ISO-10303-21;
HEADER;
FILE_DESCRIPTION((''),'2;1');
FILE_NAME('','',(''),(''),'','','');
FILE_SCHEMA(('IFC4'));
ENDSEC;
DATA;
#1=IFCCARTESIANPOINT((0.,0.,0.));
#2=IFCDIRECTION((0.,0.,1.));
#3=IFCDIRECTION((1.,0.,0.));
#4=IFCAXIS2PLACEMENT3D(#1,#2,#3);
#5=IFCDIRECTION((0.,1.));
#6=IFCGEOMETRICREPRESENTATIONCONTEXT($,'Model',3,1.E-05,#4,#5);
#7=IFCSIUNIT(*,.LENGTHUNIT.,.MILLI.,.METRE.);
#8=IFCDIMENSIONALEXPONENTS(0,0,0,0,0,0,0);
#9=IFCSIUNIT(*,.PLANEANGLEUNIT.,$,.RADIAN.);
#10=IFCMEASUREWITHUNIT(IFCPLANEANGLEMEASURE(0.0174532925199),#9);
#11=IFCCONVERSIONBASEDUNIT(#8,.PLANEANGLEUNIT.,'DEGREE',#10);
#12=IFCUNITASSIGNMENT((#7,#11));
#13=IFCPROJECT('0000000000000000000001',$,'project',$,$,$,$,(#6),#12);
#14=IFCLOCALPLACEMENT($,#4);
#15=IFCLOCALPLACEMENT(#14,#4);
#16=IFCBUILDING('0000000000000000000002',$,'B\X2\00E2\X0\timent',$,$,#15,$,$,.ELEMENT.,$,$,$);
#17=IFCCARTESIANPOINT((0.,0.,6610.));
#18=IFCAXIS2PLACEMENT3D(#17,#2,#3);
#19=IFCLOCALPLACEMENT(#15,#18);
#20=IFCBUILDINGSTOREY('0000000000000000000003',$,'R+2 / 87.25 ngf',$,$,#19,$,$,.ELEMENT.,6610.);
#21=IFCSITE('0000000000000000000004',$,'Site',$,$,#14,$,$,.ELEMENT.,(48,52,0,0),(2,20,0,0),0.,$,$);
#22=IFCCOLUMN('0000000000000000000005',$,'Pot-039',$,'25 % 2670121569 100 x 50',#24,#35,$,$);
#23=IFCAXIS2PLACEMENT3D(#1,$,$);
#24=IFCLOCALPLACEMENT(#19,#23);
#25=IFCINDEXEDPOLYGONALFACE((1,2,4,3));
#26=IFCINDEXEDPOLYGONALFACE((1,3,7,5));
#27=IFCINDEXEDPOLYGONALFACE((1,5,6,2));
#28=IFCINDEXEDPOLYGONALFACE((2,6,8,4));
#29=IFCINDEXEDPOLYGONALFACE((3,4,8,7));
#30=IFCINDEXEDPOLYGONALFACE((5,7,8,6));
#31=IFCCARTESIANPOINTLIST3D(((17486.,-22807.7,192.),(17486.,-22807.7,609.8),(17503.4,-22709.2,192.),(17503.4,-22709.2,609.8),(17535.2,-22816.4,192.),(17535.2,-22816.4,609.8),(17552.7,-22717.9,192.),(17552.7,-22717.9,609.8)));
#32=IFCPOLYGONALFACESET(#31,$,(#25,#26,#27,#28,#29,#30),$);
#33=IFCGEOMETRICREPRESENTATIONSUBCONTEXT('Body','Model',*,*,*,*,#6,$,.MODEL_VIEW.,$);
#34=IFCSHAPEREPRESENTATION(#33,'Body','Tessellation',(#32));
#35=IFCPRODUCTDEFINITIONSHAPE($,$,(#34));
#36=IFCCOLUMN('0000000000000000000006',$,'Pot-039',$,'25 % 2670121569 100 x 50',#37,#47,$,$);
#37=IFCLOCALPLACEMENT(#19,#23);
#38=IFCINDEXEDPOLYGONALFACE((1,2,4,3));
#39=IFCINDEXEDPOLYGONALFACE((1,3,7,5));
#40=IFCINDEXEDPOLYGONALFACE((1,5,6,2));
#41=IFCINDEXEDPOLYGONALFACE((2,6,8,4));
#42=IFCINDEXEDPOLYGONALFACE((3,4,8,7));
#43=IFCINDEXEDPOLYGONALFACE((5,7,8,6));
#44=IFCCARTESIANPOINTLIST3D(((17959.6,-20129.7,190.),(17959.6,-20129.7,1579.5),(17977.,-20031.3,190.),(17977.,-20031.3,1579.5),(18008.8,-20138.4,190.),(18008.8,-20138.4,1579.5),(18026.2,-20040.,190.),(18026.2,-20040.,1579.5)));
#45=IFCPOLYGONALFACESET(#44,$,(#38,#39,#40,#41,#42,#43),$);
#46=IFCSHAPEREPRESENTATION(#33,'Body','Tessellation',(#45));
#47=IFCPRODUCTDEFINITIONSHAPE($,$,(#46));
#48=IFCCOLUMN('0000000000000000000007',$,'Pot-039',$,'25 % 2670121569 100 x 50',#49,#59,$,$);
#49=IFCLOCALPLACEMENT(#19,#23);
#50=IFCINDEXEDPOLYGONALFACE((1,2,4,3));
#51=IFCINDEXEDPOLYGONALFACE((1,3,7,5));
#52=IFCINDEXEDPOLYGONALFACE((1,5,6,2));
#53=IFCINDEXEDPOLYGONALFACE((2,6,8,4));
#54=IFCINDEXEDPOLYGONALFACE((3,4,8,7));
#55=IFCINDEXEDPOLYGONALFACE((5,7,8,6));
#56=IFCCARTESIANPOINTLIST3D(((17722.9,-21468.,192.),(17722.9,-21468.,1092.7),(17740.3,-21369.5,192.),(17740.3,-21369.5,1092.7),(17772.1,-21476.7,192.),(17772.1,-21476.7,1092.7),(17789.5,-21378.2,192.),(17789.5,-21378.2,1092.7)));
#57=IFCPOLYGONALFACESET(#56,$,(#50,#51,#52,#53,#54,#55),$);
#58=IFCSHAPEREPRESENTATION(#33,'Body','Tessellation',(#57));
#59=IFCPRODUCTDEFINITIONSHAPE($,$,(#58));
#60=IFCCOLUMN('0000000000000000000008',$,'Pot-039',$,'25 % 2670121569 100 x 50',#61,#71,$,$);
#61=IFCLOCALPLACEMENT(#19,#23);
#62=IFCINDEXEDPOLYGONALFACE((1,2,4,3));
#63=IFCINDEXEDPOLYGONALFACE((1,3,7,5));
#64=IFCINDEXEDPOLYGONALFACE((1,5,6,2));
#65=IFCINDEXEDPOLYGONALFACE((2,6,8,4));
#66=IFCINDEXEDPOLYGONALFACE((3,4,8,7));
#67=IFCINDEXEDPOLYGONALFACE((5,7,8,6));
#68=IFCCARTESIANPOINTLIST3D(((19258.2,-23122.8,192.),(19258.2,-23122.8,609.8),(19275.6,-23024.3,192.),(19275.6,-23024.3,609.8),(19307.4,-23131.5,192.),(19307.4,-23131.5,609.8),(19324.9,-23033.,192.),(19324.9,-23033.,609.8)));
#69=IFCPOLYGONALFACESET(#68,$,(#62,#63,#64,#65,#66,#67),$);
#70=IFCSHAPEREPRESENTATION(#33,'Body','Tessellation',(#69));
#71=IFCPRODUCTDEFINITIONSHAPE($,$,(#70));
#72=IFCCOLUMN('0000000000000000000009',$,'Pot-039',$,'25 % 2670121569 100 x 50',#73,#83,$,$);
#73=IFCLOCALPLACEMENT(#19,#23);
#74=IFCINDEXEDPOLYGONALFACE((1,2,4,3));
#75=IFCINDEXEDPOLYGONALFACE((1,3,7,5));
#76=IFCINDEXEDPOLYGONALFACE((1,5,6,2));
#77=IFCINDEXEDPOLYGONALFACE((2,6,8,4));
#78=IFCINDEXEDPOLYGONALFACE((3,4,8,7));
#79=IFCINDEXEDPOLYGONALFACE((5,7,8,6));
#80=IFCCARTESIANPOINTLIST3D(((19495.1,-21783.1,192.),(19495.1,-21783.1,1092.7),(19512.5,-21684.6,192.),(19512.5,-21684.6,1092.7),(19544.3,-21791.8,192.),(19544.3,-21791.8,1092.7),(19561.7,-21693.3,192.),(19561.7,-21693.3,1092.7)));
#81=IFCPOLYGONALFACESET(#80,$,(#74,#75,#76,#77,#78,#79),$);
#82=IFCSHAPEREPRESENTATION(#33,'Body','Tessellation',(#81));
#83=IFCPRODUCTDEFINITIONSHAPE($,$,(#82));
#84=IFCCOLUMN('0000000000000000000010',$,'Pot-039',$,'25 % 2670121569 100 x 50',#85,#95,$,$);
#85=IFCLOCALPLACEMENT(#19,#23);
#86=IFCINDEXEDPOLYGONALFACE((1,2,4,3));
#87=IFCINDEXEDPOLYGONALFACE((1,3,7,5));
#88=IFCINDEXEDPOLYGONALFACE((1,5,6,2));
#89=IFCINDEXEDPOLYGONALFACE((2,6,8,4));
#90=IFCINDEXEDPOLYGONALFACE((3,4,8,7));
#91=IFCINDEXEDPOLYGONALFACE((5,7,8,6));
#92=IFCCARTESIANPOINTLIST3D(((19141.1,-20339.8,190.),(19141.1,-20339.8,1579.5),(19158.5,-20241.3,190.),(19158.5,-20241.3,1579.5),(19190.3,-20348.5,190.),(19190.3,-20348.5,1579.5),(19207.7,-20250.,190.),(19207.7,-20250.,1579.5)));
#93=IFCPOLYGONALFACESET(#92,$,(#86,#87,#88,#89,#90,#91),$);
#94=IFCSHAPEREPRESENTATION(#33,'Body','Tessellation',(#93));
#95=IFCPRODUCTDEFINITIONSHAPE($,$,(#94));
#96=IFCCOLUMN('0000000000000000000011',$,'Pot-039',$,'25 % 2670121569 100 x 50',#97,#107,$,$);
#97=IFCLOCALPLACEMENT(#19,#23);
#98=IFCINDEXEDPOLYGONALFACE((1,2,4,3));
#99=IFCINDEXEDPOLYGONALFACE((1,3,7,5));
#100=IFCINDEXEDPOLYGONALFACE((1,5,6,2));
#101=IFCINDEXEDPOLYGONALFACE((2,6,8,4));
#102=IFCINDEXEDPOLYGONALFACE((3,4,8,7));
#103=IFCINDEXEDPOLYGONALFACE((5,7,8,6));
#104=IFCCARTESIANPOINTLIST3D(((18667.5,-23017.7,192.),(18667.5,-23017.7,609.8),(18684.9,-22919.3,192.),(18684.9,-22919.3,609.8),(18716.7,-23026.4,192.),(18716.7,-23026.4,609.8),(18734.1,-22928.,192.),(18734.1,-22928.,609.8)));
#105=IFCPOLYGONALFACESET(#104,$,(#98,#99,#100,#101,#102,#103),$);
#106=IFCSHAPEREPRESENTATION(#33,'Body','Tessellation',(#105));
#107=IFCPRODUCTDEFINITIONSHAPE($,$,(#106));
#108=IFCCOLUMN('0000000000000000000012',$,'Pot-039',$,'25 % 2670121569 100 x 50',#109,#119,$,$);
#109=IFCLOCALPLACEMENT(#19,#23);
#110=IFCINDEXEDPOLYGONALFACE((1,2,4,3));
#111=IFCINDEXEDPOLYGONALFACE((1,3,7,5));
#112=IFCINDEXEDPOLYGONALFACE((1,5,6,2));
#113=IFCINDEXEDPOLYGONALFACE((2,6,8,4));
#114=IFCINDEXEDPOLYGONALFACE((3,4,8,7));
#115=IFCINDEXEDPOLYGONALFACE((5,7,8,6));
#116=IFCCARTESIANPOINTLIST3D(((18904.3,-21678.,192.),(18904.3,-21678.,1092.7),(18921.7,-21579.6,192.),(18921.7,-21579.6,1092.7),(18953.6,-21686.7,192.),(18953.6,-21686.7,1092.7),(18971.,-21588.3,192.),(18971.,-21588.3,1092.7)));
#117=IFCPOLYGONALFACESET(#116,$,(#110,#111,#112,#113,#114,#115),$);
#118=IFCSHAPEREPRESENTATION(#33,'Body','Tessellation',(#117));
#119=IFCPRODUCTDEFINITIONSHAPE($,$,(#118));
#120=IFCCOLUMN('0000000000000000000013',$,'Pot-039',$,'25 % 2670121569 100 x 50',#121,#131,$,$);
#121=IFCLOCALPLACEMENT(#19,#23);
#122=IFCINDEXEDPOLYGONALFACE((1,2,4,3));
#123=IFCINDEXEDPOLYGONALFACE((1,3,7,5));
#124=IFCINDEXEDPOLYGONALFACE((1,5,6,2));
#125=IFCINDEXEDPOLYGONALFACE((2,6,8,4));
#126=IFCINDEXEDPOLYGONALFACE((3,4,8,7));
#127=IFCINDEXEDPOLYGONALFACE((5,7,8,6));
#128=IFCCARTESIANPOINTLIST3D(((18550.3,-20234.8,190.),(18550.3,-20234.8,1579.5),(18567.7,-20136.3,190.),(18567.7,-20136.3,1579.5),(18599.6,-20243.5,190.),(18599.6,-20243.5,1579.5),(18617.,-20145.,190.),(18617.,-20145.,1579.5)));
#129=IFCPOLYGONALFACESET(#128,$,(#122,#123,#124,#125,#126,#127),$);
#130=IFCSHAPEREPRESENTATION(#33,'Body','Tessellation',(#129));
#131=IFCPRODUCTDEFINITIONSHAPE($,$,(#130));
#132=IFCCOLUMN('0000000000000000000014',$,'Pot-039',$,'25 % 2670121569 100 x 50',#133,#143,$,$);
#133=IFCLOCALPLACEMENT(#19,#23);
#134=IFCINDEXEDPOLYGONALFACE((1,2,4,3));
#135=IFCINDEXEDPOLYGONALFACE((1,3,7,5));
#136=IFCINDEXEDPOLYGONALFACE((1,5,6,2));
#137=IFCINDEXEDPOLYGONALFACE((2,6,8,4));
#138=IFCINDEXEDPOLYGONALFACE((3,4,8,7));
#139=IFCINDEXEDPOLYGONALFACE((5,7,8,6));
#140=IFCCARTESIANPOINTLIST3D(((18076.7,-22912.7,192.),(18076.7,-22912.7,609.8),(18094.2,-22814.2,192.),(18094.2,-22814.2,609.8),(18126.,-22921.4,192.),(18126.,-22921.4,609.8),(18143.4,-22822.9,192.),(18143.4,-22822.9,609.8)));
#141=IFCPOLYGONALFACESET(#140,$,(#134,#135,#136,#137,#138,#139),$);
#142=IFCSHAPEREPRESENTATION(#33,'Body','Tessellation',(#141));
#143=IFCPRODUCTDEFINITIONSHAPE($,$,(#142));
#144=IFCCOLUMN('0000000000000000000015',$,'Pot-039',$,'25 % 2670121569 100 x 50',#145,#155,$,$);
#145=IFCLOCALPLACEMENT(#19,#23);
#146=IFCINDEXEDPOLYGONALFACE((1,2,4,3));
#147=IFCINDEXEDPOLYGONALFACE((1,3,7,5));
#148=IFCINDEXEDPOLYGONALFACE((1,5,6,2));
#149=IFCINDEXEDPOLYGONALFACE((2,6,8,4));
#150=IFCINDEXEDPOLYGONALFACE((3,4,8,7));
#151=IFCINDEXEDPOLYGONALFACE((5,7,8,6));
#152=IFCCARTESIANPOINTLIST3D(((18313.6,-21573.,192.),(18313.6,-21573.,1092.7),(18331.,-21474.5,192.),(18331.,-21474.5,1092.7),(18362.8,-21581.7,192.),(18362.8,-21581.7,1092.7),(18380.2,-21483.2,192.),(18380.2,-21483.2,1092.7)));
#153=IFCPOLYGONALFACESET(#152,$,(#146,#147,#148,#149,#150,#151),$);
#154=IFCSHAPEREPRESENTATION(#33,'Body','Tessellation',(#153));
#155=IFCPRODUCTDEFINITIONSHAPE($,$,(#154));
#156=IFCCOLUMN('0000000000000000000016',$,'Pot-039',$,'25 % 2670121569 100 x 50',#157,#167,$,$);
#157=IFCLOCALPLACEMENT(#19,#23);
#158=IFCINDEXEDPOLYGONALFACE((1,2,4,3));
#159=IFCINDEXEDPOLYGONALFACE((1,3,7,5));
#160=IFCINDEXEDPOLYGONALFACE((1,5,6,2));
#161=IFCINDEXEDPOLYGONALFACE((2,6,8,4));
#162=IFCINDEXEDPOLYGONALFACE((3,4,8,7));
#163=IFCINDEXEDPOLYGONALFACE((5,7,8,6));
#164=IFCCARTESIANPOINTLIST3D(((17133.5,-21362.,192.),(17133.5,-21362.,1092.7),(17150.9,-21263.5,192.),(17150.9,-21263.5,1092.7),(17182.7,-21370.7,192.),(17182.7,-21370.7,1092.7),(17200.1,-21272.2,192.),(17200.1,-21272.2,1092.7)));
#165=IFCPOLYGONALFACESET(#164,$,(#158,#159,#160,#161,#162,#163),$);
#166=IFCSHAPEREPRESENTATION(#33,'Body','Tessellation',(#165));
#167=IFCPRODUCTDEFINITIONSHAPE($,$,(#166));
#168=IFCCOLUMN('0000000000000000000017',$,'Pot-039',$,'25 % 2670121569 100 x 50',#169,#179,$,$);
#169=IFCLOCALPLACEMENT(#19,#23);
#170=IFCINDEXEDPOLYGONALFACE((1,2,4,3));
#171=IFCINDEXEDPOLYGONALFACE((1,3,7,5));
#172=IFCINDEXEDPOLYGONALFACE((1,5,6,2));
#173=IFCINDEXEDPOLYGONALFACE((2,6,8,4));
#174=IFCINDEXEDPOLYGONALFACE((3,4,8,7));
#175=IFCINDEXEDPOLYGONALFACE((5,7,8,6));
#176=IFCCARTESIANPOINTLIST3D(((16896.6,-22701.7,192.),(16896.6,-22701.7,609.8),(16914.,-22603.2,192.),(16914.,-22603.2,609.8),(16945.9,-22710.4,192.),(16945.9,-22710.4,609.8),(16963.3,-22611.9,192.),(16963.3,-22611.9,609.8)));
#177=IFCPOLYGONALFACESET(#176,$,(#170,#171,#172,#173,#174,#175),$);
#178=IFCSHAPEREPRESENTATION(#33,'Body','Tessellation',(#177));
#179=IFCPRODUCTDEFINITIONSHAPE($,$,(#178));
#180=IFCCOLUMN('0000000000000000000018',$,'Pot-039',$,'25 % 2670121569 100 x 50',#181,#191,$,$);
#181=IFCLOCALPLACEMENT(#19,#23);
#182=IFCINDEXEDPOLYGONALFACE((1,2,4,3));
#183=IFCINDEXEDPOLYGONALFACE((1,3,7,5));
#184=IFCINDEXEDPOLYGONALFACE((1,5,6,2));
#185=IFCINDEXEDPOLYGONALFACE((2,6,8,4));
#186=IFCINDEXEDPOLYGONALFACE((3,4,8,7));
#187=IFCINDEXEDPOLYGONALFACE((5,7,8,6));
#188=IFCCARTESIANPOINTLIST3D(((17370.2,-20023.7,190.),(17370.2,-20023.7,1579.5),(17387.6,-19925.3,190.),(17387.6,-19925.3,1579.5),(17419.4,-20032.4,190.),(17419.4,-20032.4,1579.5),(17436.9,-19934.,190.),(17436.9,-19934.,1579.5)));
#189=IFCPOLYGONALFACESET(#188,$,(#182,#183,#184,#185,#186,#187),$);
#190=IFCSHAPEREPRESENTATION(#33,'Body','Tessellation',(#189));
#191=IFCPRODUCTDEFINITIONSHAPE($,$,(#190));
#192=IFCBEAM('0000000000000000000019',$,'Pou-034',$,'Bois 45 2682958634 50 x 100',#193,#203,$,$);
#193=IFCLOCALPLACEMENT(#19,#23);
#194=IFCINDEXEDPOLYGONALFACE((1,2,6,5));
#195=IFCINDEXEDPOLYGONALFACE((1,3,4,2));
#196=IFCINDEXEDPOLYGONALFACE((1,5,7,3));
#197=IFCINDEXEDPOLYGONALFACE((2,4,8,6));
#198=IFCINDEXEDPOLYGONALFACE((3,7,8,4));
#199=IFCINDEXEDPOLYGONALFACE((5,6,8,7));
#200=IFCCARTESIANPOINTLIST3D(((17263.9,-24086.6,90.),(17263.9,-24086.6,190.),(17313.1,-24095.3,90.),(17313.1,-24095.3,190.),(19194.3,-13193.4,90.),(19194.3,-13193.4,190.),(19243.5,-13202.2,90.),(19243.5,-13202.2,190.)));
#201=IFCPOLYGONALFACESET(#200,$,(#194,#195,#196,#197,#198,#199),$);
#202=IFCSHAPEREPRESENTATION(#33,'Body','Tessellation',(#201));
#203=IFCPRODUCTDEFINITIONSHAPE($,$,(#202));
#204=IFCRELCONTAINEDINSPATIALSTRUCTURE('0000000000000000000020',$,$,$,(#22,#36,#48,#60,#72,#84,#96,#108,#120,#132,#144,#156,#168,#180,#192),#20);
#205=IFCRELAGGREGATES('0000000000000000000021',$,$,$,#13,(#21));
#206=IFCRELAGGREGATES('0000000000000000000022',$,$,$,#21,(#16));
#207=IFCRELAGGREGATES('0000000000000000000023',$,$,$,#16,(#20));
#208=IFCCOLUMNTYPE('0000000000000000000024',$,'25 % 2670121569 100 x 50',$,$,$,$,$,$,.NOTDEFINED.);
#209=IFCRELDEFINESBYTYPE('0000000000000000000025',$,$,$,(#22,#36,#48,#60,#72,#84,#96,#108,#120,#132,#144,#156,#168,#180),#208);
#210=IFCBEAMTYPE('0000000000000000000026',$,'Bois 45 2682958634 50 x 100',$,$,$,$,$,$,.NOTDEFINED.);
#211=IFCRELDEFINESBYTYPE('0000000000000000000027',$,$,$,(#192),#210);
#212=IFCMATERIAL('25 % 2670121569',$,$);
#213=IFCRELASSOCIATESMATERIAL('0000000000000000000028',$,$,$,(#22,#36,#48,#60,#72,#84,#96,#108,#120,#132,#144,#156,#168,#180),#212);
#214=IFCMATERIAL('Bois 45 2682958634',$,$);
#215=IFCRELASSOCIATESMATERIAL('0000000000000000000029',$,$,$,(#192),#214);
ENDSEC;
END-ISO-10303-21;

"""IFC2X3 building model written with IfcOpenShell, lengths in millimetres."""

from ifc_helpers import new_model, entity, si_unit, converted_unit, direction, frame, frame_2d, origin_with_axes, origin_2d_with_axis, place, context, subcontext, project, spatial, rectangle, extrude, material, type_object, element, save


model = new_model("IFC2X3")

# Units and contexts
model_context = context("Model", 3, precision=1e-05, world=origin_with_axes(), true_north=direction((0.0, 1.0)))
body_context = subcontext(model_context, "Body", "Model", "MODEL_VIEW")
ifc_project = project(units=[si_unit("LENGTHUNIT", "METRE", prefix="MILLI"), converted_unit("PLANEANGLEUNIT", "DEGREE", entity("IfcPlaneAngleMeasure", 0.0174532925199), si_unit("PLANEANGLEUNIT", "RADIAN"), dimensions=[0, 0, 0, 0, 0, 0, 0])], contexts=[model_context])

# Site, building, storey
site_placement = place(None, origin_with_axes())
site = spatial("IfcSite", under=ifc_project, at=site_placement, Name="Site", CompositionType="ELEMENT", RefLatitude=(48, 52, 0, 0), RefLongitude=(2, 20, 0, 0), RefElevation=0.0)
building_placement = place(site_placement, origin_with_axes())
building = spatial("IfcBuilding", under=site, at=building_placement, Name="Bâtiment", CompositionType="ELEMENT")
storey_placement = place(building_placement, frame((0.0, 0.0, 6610.0), z_axis=(0.0, 0.0, 1.0), x_axis=(1.0, 0.0, 0.0)))
storey = spatial("IfcBuildingStorey", under=building, at=storey_placement, Name="R+2 / 87.25 ngf", CompositionType="ELEMENT", Elevation=6610.0)

# Columns
ifc_material_1 = material(Name="25 % 2670121569")
column_type = type_object("IfcColumnType", Name="25 % 2670121569 100 x 50", PredefinedType="NOTDEFINED")
column_1_placement = place(storey_placement, frame((17519.3, -22762.8, 192.0), z_axis=(0.0, 0.0, 1.0), x_axis=(0.17408, 0.984731, 0.0)))
element("IfcColumn", 1, at=column_1_placement, inside=storey, type_object=column_type, material=ifc_material_1, Name="Pot-039", ObjectType="25 % 2670121569 100 x 50", context=body_context, shape_type="SweptSolid", body=[
    extrude(rectangle(XDim=100.0, YDim=50.0, at=origin_2d_with_axis()), origin_with_axes(), (0.0, 0.0, 1.0), 417.8),
])
column_2_placement = place(storey_placement, frame((17992.9, -20084.9, 190.0), z_axis=(0.0, 0.0, 1.0), x_axis=(0.17408, 0.984731, 0.0)))
element("IfcColumn", 2, at=column_2_placement, inside=storey, type_object=column_type, material=ifc_material_1, Name="Pot-039", ObjectType="25 % 2670121569 100 x 50", context=body_context, shape_type="SweptSolid", body=[
    extrude(rectangle(XDim=100.0, YDim=50.0, at=origin_2d_with_axis()), origin_with_axes(), (0.0, 0.0, 1.0), 1389.5),
])
column_3_placement = place(storey_placement, frame((17756.2, -21423.1, 192.0), z_axis=(0.0, 0.0, 1.0), x_axis=(0.17408, 0.984731, 0.0)))
element("IfcColumn", 3, at=column_3_placement, inside=storey, type_object=column_type, material=ifc_material_1, Name="Pot-039", ObjectType="25 % 2670121569 100 x 50", context=body_context, shape_type="SweptSolid", body=[
    extrude(rectangle(XDim=100.0, YDim=50.0, at=origin_2d_with_axis()), origin_with_axes(), (0.0, 0.0, 1.0), 900.7),
])
column_4_placement = place(storey_placement, frame((19291.5, -23077.9, 192.0), z_axis=(0.0, 0.0, 1.0), x_axis=(0.17408, 0.984731, 0.0)))
element("IfcColumn", 4, at=column_4_placement, inside=storey, type_object=column_type, material=ifc_material_1, Name="Pot-039", ObjectType="25 % 2670121569 100 x 50", context=body_context, shape_type="SweptSolid", body=[
    extrude(rectangle(XDim=100.0, YDim=50.0, at=origin_2d_with_axis()), origin_with_axes(), (0.0, 0.0, 1.0), 417.8),
])
column_5_placement = place(storey_placement, frame((19528.4, -21738.2, 192.0), z_axis=(0.0, 0.0, 1.0), x_axis=(0.17408, 0.984731, 0.0)))
element("IfcColumn", 5, at=column_5_placement, inside=storey, type_object=column_type, material=ifc_material_1, Name="Pot-039", ObjectType="25 % 2670121569 100 x 50", context=body_context, shape_type="SweptSolid", body=[
    extrude(rectangle(XDim=100.0, YDim=50.0, at=origin_2d_with_axis()), origin_with_axes(), (0.0, 0.0, 1.0), 900.7),
])
column_6_placement = place(storey_placement, frame((19174.4, -20294.9, 190.0), z_axis=(0.0, 0.0, 1.0), x_axis=(0.17408, 0.984731, 0.0)))
element("IfcColumn", 6, at=column_6_placement, inside=storey, type_object=column_type, material=ifc_material_1, Name="Pot-039", ObjectType="25 % 2670121569 100 x 50", context=body_context, shape_type="SweptSolid", body=[
    extrude(rectangle(XDim=100.0, YDim=50.0, at=origin_2d_with_axis()), origin_with_axes(), (0.0, 0.0, 1.0), 1389.5),
])
column_7_placement = place(storey_placement, frame((18700.8, -22972.8, 192.0), z_axis=(0.0, 0.0, 1.0), x_axis=(0.17408, 0.984731, 0.0)))
element("IfcColumn", 7, at=column_7_placement, inside=storey, type_object=column_type, material=ifc_material_1, Name="Pot-039", ObjectType="25 % 2670121569 100 x 50", context=body_context, shape_type="SweptSolid", body=[
    extrude(rectangle(XDim=100.0, YDim=50.0, at=origin_2d_with_axis()), origin_with_axes(), (0.0, 0.0, 1.0), 417.8),
])
column_8_placement = place(storey_placement, frame((18937.6, -21633.1, 192.0), z_axis=(0.0, 0.0, 1.0), x_axis=(0.17408, 0.984731, 0.0)))
element("IfcColumn", 8, at=column_8_placement, inside=storey, type_object=column_type, material=ifc_material_1, Name="Pot-039", ObjectType="25 % 2670121569 100 x 50", context=body_context, shape_type="SweptSolid", body=[
    extrude(rectangle(XDim=100.0, YDim=50.0, at=origin_2d_with_axis()), origin_with_axes(), (0.0, 0.0, 1.0), 900.7),
])
column_9_placement = place(storey_placement, frame((18583.6, -20189.9, 190.0), z_axis=(0.0, 0.0, 1.0), x_axis=(0.17408, 0.984731, 0.0)))
element("IfcColumn", 9, at=column_9_placement, inside=storey, type_object=column_type, material=ifc_material_1, Name="Pot-039", ObjectType="25 % 2670121569 100 x 50", context=body_context, shape_type="SweptSolid", body=[
    extrude(rectangle(XDim=100.0, YDim=50.0, at=origin_2d_with_axis()), origin_with_axes(), (0.0, 0.0, 1.0), 1389.5),
])
column_10_placement = place(storey_placement, frame((18110.1, -22867.8, 192.0), z_axis=(0.0, 0.0, 1.0), x_axis=(0.17408, 0.984731, 0.0)))
element("IfcColumn", 10, at=column_10_placement, inside=storey, type_object=column_type, material=ifc_material_1, Name="Pot-039", ObjectType="25 % 2670121569 100 x 50", context=body_context, shape_type="SweptSolid", body=[
    extrude(rectangle(XDim=100.0, YDim=50.0, at=origin_2d_with_axis()), origin_with_axes(), (0.0, 0.0, 1.0), 417.8),
])
for number, where, z_axis, x_axis, name in (
    (11, (18346.9, -21528.1, 192.0), (0.0, 0.0, 1.0), (0.17408, 0.984731, 0.0), "Pot-039"),
    (12, (17166.8, -21317.1, 192.0), (0.0, 0.0, 1.0), (0.17408, 0.984731, 0.0), "Pot-039"),
):
    element("IfcColumn", number, at=place(storey_placement, frame(where, z_axis=z_axis, x_axis=x_axis)), inside=storey, type_object=column_type, material=ifc_material_1, Name=name, ObjectType="25 % 2670121569 100 x 50", context=body_context, shape_type="SweptSolid", body=[
        extrude(rectangle(XDim=100.0, YDim=50.0, at=origin_2d_with_axis()), origin_with_axes(), (0.0, 0.0, 1.0), 900.7),
    ])
column_11_placement = place(storey_placement, frame((16930.0, -22656.8, 192.0), z_axis=(0.0, 0.0, 1.0), x_axis=(0.17408, 0.984731, 0.0)))
element("IfcColumn", 13, at=column_11_placement, inside=storey, type_object=column_type, material=ifc_material_1, Name="Pot-039", ObjectType="25 % 2670121569 100 x 50", context=body_context, shape_type="SweptSolid", body=[
    extrude(rectangle(XDim=100.0, YDim=50.0, at=origin_2d_with_axis()), origin_with_axes(), (0.0, 0.0, 1.0), 417.8),
])
column_12_placement = place(storey_placement, frame((17403.5, -19978.9, 190.0), z_axis=(0.0, 0.0, 1.0), x_axis=(0.17408, 0.984731, 0.0)))
element("IfcColumn", 14, at=column_12_placement, inside=storey, type_object=column_type, material=ifc_material_1, Name="Pot-039", ObjectType="25 % 2670121569 100 x 50", context=body_context, shape_type="SweptSolid", body=[
    extrude(rectangle(XDim=100.0, YDim=50.0, at=origin_2d_with_axis()), origin_with_axes(), (0.0, 0.0, 1.0), 1389.5),
])

# Beam
ifc_material_2 = material(Name="Bois 45 2682958634")
beam_type = type_object("IfcBeamType", Name="Bois 45 2682958634 50 x 100", PredefinedType="NOTDEFINED")
for number, where, z_axis, x_axis, name in (
    (15, (17288.5, -24091.0, 190.0), (0.0, 0.0, 1.0), (0.984659, -0.174492, 0.0), "Pou-034"),
):
    element("IfcBeam", number, at=place(storey_placement, frame(where, z_axis=z_axis, x_axis=x_axis)), inside=storey, type_object=beam_type, material=ifc_material_2, Name=name, ObjectType="Bois 45 2682958634 50 x 100", context=body_context, shape_type="SweptSolid", body=[
        extrude(rectangle(XDim=100.0, YDim=50.0, at=frame_2d((-50.0, 0.0), x_axis=(1.0, 0.0))), frame((0.0, 0.0, 0.0), z_axis=(0.0, 1.0, 0.0), x_axis=(0.0, 0.0, 1.0)), (0.0, 0.0, 1.0), 11062.9),
    ])

save(model, "model.ifc")
